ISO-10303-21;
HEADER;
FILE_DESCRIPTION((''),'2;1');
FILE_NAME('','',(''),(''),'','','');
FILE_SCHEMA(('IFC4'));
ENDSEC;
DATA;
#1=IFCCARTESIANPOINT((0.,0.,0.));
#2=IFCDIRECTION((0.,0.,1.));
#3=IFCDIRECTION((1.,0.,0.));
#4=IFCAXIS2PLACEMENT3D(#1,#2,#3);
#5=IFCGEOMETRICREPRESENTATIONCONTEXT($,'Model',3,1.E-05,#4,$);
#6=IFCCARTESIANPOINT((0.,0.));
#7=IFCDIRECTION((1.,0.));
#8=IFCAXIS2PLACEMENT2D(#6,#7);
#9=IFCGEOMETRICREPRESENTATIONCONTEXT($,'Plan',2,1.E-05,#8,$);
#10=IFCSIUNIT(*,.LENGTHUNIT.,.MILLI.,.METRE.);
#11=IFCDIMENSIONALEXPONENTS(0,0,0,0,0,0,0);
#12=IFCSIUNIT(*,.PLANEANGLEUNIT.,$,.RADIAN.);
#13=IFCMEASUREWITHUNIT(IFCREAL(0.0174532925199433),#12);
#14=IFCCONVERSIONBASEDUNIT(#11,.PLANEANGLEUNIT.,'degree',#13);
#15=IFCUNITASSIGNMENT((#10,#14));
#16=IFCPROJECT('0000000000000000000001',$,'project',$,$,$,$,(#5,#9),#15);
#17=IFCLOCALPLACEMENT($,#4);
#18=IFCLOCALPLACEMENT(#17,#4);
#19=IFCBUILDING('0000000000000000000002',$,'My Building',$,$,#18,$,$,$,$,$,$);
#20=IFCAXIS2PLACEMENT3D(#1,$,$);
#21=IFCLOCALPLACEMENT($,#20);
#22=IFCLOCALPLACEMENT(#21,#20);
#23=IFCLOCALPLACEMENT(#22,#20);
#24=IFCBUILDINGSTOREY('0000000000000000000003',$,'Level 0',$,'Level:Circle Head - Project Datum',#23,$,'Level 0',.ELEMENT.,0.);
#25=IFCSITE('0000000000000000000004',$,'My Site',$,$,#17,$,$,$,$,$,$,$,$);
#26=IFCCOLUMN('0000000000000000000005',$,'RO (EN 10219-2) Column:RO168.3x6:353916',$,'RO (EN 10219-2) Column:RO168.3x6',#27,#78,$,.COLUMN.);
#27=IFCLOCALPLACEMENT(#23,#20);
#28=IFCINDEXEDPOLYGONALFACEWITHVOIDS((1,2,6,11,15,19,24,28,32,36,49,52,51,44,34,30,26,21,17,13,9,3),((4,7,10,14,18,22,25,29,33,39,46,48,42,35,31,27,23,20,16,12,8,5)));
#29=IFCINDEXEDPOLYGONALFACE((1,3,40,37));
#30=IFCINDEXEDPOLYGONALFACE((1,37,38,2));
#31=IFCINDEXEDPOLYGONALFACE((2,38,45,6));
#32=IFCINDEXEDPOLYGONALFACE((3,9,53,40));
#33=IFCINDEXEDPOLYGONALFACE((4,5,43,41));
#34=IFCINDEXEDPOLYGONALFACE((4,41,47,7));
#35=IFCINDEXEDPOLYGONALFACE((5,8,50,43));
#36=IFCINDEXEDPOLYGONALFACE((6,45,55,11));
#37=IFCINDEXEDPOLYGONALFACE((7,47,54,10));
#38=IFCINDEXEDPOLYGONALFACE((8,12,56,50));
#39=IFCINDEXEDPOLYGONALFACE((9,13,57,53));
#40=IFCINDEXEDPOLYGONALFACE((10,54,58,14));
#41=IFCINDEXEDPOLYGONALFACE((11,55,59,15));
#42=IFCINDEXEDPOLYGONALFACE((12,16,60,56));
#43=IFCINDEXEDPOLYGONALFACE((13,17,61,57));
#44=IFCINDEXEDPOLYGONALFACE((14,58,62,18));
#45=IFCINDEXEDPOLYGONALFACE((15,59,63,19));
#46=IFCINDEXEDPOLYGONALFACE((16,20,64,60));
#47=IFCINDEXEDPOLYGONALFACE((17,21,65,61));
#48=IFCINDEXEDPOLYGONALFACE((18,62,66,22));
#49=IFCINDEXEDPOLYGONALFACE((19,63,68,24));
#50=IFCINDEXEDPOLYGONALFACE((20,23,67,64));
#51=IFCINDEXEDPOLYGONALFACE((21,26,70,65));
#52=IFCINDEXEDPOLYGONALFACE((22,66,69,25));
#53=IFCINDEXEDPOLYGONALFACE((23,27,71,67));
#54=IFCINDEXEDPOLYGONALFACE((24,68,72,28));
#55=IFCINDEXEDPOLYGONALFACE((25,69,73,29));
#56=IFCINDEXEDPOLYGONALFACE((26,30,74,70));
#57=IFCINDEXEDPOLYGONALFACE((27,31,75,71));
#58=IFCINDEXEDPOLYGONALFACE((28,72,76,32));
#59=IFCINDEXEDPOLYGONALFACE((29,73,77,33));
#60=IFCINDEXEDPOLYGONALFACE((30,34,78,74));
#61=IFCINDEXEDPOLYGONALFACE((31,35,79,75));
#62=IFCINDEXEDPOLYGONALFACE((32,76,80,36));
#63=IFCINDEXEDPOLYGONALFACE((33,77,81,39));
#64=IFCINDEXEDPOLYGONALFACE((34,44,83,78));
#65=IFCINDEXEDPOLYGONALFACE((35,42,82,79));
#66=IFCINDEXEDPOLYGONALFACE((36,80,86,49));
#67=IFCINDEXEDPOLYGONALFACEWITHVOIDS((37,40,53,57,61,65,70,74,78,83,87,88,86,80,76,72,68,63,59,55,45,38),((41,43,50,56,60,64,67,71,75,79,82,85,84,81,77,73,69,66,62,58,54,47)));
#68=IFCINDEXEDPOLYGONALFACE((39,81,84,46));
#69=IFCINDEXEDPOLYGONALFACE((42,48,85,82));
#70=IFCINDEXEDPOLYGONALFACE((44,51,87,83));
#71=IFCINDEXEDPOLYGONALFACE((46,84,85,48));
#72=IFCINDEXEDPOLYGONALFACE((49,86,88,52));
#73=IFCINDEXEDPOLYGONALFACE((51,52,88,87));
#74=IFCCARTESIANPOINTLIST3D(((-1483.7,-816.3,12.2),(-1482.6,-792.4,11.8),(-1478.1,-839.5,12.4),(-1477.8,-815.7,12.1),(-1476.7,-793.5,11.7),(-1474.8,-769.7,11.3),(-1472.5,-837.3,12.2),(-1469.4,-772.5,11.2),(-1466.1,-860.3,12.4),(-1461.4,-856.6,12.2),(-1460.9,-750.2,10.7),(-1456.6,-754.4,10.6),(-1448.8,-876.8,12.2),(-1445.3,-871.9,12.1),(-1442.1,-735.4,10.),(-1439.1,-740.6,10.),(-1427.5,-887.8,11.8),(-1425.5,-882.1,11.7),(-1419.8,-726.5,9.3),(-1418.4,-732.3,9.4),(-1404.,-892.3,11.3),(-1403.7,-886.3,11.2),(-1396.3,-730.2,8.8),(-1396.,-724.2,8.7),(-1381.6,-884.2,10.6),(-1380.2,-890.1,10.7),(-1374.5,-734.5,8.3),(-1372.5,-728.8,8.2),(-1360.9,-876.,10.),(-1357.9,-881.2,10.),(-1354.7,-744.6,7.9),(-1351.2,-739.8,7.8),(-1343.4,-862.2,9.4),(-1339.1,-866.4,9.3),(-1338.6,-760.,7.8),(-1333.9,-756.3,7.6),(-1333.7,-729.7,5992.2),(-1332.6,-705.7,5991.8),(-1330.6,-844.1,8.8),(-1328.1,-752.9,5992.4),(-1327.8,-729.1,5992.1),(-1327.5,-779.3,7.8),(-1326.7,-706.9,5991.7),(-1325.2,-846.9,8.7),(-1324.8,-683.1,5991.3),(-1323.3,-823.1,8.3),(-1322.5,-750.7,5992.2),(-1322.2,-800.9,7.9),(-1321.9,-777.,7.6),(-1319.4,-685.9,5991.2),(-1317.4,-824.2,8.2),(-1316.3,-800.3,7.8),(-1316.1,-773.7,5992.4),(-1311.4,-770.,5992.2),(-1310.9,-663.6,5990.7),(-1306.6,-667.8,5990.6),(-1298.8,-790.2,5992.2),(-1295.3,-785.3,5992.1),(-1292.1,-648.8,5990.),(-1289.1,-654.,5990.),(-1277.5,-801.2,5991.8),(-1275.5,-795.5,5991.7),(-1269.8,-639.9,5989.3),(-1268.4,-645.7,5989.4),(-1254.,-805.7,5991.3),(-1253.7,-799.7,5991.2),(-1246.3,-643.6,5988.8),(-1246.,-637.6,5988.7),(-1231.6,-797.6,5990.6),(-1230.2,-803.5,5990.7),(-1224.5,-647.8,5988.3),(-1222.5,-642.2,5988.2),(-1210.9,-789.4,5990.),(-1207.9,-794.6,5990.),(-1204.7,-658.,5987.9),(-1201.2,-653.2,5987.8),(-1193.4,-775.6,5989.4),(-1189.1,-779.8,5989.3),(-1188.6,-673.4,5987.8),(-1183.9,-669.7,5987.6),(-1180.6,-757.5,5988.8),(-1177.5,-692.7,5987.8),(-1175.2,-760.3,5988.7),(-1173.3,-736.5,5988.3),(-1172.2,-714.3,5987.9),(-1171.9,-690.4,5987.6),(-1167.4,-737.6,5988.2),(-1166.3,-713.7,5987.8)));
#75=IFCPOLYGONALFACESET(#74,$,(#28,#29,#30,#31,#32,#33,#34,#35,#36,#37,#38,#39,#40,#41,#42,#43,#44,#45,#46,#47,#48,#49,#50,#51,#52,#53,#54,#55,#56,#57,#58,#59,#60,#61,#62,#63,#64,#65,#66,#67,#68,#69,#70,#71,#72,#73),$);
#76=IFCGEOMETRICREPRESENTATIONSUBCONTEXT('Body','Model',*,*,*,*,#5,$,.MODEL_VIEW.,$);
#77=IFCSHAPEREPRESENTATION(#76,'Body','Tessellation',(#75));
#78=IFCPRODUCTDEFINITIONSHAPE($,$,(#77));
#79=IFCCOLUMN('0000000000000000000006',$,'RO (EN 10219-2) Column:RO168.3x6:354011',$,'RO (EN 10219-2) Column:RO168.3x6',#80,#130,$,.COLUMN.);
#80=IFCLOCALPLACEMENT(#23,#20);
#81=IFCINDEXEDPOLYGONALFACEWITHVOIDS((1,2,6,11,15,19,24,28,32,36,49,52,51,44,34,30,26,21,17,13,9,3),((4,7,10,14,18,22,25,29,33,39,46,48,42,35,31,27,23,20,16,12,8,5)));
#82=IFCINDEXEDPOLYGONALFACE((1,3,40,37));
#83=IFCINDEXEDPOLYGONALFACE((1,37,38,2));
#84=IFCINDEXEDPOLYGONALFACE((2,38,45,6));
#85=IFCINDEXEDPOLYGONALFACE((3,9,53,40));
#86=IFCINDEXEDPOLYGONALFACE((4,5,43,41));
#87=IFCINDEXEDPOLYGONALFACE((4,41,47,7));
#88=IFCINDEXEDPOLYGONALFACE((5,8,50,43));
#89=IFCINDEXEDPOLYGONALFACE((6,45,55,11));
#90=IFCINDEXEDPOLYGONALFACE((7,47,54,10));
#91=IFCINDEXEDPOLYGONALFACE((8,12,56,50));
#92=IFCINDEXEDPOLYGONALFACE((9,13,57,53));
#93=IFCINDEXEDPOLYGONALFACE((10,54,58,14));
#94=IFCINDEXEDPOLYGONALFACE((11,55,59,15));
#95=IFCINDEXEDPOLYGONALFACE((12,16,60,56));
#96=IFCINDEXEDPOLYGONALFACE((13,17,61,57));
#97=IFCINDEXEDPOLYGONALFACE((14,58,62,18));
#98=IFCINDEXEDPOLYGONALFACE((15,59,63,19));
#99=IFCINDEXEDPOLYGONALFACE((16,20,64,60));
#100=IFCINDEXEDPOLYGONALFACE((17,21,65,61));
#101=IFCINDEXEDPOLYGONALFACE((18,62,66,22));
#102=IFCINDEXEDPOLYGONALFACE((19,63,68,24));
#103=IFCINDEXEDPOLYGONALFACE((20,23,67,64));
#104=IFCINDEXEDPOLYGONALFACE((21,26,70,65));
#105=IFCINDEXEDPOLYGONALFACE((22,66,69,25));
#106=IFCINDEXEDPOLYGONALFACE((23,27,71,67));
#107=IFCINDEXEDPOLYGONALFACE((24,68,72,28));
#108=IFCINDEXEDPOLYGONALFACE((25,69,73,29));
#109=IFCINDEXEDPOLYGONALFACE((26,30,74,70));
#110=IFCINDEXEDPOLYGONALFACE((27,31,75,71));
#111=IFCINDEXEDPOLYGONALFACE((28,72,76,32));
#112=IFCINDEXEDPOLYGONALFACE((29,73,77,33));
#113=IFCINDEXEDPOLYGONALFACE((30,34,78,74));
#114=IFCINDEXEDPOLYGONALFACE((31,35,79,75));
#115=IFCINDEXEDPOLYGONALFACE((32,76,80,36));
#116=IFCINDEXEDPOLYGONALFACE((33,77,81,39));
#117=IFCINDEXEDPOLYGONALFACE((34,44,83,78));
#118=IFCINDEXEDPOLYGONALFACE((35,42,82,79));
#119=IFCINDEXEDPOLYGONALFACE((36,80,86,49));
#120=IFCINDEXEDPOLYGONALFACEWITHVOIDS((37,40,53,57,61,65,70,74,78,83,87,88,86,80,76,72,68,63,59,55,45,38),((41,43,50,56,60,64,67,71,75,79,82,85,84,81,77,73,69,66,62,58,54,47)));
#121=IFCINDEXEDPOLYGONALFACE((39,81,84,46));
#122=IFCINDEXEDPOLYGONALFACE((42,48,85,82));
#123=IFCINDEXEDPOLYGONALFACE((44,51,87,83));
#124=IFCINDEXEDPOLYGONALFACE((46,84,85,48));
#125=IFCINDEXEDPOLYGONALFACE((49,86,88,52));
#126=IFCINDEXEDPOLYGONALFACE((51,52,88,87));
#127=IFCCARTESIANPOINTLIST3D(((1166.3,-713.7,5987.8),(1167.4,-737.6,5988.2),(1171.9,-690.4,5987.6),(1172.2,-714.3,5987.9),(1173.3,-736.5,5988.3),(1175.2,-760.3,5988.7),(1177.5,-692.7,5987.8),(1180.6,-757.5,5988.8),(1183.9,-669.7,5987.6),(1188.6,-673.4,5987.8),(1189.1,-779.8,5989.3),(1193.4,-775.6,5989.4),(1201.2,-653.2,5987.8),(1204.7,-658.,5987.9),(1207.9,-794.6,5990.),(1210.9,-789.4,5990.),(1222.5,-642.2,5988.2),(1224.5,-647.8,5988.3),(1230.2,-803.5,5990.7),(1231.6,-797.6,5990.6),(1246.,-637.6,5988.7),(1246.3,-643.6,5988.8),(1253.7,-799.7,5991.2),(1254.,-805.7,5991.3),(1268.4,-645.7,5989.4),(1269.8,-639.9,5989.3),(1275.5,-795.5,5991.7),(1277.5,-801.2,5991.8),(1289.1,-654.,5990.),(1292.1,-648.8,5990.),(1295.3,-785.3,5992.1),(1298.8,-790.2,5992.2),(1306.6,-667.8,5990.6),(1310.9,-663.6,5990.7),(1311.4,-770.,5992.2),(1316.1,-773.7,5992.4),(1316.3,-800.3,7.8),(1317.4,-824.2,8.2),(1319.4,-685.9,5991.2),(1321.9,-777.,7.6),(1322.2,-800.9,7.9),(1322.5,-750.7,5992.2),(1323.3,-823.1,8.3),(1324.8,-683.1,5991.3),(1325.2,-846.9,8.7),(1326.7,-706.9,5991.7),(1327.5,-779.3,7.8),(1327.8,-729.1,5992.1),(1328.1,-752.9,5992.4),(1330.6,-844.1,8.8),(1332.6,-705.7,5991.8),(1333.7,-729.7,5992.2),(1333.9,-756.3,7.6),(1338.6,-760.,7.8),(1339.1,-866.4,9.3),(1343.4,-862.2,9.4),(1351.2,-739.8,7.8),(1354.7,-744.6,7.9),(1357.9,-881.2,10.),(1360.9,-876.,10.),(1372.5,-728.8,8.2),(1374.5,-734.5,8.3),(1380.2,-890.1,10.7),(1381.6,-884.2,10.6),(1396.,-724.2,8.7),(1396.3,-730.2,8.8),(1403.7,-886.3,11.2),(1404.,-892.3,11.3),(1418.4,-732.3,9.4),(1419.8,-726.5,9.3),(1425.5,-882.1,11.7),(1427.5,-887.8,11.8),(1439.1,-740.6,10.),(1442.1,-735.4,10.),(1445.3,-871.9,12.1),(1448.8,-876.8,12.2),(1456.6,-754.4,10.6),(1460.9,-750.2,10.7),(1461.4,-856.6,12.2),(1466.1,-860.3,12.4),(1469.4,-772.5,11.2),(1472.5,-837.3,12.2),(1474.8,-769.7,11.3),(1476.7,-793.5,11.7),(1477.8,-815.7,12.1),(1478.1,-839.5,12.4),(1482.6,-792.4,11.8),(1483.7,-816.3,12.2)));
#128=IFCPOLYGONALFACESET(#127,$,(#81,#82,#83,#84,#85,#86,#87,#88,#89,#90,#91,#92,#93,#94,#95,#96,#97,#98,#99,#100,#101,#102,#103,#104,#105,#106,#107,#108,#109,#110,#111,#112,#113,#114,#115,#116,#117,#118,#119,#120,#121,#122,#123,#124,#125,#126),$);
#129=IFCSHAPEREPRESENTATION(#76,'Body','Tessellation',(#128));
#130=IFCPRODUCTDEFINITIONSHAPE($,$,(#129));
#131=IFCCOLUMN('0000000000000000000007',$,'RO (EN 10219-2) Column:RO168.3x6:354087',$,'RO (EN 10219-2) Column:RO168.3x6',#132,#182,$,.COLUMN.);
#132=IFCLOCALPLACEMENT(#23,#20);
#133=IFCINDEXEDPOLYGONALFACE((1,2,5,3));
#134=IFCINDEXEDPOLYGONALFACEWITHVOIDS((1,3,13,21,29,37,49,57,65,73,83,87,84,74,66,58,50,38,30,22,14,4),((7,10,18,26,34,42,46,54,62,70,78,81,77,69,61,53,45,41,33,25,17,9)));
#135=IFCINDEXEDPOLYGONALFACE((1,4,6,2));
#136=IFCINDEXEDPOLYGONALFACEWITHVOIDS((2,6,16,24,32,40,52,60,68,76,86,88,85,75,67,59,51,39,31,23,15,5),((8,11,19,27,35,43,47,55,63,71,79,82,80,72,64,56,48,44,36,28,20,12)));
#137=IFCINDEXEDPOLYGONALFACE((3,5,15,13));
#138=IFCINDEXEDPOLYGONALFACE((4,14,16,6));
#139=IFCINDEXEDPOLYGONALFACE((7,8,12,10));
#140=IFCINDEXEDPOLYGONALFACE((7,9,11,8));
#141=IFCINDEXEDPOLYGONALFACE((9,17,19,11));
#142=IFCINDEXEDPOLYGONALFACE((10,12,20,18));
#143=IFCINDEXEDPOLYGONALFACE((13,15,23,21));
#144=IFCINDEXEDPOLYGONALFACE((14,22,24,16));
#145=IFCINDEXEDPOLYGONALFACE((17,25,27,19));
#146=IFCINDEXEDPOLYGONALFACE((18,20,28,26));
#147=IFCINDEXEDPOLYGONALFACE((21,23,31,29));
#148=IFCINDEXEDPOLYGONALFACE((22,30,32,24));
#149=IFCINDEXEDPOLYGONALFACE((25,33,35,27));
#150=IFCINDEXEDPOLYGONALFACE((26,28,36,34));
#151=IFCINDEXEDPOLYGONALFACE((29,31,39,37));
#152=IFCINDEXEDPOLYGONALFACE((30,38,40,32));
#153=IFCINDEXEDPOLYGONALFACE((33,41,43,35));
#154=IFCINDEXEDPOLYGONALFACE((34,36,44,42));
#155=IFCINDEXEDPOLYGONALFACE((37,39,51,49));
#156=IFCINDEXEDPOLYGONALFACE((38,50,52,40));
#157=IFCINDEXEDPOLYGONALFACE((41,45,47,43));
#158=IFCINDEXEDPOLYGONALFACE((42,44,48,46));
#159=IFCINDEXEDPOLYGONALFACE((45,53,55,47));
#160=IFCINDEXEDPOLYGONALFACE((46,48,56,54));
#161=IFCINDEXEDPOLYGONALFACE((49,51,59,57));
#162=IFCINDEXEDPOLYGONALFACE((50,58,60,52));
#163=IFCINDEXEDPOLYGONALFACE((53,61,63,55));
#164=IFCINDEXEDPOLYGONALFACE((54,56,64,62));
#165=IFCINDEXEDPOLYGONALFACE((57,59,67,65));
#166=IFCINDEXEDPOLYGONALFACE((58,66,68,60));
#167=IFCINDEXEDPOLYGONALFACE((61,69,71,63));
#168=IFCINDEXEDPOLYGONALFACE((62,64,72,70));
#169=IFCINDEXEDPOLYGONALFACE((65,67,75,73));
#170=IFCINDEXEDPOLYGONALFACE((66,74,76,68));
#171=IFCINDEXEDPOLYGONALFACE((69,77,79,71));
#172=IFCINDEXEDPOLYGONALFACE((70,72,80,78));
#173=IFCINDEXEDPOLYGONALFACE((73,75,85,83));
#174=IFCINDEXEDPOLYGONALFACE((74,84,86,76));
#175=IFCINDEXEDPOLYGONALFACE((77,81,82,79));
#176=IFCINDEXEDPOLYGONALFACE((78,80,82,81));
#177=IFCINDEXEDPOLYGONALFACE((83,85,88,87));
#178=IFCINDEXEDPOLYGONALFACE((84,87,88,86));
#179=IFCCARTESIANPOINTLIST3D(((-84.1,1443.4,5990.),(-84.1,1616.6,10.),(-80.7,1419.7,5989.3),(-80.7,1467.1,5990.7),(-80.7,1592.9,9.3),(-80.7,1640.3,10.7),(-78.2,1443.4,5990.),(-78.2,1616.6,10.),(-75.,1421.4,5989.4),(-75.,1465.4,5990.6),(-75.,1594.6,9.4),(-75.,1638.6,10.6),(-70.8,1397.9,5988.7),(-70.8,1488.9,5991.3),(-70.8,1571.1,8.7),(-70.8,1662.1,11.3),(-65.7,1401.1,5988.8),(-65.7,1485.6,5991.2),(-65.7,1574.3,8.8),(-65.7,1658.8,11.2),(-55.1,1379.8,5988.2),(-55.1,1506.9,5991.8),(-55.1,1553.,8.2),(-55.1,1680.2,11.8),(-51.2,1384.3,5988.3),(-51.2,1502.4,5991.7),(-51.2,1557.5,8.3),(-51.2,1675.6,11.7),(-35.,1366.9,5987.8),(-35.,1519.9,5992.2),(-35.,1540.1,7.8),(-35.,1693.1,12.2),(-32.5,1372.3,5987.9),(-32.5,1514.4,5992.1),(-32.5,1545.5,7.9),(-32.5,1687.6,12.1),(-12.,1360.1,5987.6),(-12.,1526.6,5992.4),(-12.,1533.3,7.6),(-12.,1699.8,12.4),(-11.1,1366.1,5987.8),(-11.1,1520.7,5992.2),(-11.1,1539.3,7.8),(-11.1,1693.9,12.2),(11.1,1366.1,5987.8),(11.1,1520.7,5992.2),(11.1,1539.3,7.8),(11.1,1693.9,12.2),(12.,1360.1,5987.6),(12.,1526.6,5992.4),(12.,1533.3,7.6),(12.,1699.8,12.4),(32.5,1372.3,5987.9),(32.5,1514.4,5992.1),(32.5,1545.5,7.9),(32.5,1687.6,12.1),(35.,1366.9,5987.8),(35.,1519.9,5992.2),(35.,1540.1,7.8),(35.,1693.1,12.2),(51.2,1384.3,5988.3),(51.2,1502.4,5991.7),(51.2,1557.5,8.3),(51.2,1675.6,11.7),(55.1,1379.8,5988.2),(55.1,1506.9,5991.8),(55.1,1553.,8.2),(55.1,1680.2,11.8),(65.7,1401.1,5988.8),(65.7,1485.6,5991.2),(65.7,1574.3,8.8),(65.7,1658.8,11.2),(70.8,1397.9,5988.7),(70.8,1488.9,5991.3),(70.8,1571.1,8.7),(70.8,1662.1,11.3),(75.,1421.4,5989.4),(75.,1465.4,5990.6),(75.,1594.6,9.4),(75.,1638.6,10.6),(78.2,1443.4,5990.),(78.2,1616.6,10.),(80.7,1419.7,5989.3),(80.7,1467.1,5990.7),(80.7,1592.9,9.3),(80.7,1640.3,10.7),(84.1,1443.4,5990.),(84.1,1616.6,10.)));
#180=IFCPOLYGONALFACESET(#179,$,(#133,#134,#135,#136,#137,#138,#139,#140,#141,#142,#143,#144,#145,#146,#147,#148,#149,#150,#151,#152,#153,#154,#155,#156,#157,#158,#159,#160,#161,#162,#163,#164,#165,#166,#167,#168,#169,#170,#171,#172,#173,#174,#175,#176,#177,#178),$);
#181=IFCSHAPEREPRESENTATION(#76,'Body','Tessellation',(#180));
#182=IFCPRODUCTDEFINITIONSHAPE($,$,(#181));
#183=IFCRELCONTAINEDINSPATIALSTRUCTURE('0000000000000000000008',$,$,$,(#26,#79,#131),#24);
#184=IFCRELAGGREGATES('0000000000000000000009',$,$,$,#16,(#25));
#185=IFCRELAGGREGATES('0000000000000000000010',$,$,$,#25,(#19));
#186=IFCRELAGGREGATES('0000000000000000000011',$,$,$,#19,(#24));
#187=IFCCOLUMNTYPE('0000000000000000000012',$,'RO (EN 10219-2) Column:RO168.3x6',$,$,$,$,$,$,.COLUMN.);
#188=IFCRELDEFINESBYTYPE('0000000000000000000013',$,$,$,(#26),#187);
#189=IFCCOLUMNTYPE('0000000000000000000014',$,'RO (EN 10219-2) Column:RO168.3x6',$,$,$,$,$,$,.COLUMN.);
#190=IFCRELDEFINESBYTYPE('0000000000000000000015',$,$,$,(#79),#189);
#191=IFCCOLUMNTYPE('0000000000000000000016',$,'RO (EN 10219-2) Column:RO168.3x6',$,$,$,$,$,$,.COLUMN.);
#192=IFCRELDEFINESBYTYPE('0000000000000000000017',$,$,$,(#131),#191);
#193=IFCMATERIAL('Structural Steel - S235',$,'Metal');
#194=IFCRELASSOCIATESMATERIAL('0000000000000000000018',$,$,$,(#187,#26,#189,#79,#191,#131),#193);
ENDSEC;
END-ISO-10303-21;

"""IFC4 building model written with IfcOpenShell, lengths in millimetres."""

from ifc_helpers import new_model, entity, si_unit, converted_unit, frame, origin, origin_with_axes, origin_2d_with_axis, place, context, subcontext, project, spatial, arc, indexed_curve, outline, extrude, source, transform, mapped, material, type_object, type_shapes, element, save


model = new_model("IFC4")

# Units and contexts
model_context = context("Model", 3, precision=1e-05, world=origin_with_axes())
plan_context = context("Plan", 2, precision=1e-05, world=origin_2d_with_axis())
body_context = subcontext(model_context, "Body", "Model", "MODEL_VIEW")
ifc_project = project(units=[si_unit("LENGTHUNIT", "METRE", prefix="MILLI"), converted_unit("PLANEANGLEUNIT", "degree", entity("IfcReal", 0.0174532925199433), si_unit("PLANEANGLEUNIT", "RADIAN"), dimensions=[0, 0, 0, 0, 0, 0, 0])], contexts=[model_context, plan_context])

# Site, building, storey
site_placement = place(None, origin_with_axes())
site = spatial("IfcSite", under=ifc_project, at=site_placement, Name="My Site")
building_placement = place(site_placement, origin_with_axes())
building = spatial("IfcBuilding", under=site, at=building_placement, Name="My Building")
placement_1 = place(None, origin())
placement_2 = place(placement_1, origin())
storey_placement = place(placement_2, origin())
storey = spatial("IfcBuildingStorey", under=building, at=storey_placement, Name="Level 0", ObjectType="Level:Circle Head - Project Datum", LongName="Level 0", CompositionType="ELEMENT", Elevation=0.0)

# Columns
ifc_material_1 = material(Name="Structural Steel - S235", Category="Metal")
column_type_1 = type_object("IfcColumnType", Name="RO (EN 10219-2) Column:RO168.3x6", PredefinedType="COLUMN", material=ifc_material_1)
shared_shape_1 = source(origin(), body_context, "Body", "SweptSolid", [
    extrude(outline(indexed_curve([(-84.2, 0.0), (0.0, -84.1), (84.1, 0.0), (0.0, 84.1)], segments=[arc(1, 2, 3), arc(3, 4, 1)], self_intersect=False), holes=[indexed_curve([(-78.2, 0.0), (0.0, 78.2), (78.2, 0.0), (0.0, -78.2)], segments=[arc(1, 2, 3), arc(3, 4, 1)], self_intersect=False)]), frame((-1400.0, -808.3, 10.0), z_axis=(0.025073, 0.014476, 0.999581), x_axis=(-0.5, 0.866025, 0.0)), (0.0, 0.0, 1.0), 5982.5),
])
type_shapes(column_type_1, [shared_shape_1])
column_1_placement = place(storey_placement, origin())
element("IfcColumn", 1, at=column_1_placement, inside=storey, type_object=column_type_1, material=ifc_material_1, Name="RO (EN 10219-2) Column:RO168.3x6:353916", ObjectType="RO (EN 10219-2) Column:RO168.3x6", PredefinedType="COLUMN", context=body_context, shape_type="MappedRepresentation", body=[
    mapped(shared_shape_1, transform((0.0, 0.0, 0.0), scale=1.0)),
])
column_type_2 = type_object("IfcColumnType", Name="RO (EN 10219-2) Column:RO168.3x6", PredefinedType="COLUMN", material=ifc_material_1)
shared_shape_2 = source(origin(), body_context, "Body", "SweptSolid", [
    extrude(outline(indexed_curve([(-84.2, 0.0), (0.0, -84.1), (84.2, 0.0), (0.0, 84.1)], segments=[arc(1, 2, 3), arc(3, 4, 1)], self_intersect=False), holes=[indexed_curve([(-78.2, 0.0), (0.0, 78.2), (78.2, 0.0), (0.0, -78.2)], segments=[arc(1, 2, 3), arc(3, 4, 1)], self_intersect=False)]), frame((1250.0, -721.7, 5990.0), z_axis=(0.025073, -0.014476, -0.999581), x_axis=(-0.5, -0.866025, 0.0)), (0.0, 0.0, 1.0), 5982.5),
])
type_shapes(column_type_2, [shared_shape_2])
column_2_placement = place(storey_placement, origin())
element("IfcColumn", 2, at=column_2_placement, inside=storey, type_object=column_type_2, material=ifc_material_1, Name="RO (EN 10219-2) Column:RO168.3x6:354011", ObjectType="RO (EN 10219-2) Column:RO168.3x6", PredefinedType="COLUMN", context=body_context, shape_type="MappedRepresentation", body=[
    mapped(shared_shape_2, transform((0.0, 0.0, 0.0), scale=1.0)),
])
column_type_3 = type_object("IfcColumnType", Name="RO (EN 10219-2) Column:RO168.3x6", PredefinedType="COLUMN", material=ifc_material_1)
shared_shape_3 = source(origin(), body_context, "Body", "SweptSolid", [
    extrude(outline(indexed_curve([(-84.1, 0.0), (0.0, -84.1), (84.1, 0.0), (0.0, 84.1)], segments=[arc(1, 2, 3), arc(3, 4, 1)], self_intersect=False), holes=[indexed_curve([(-78.2, 0.0), (0.0, 78.2), (78.2, 0.0), (0.0, -78.2)], segments=[arc(1, 2, 3), arc(3, 4, 1)], self_intersect=False)]), frame((0.0, 1443.4, 5990.0), z_axis=(0.0, 0.028952, -0.999581), x_axis=(1.0, 0.0, 0.0)), (0.0, 0.0, 1.0), 5982.5),
])
type_shapes(column_type_3, [shared_shape_3])
column_3_placement = place(storey_placement, origin())
element("IfcColumn", 3, at=column_3_placement, inside=storey, type_object=column_type_3, material=ifc_material_1, Name="RO (EN 10219-2) Column:RO168.3x6:354087", ObjectType="RO (EN 10219-2) Column:RO168.3x6", PredefinedType="COLUMN", context=body_context, shape_type="MappedRepresentation", body=[
    mapped(shared_shape_3, transform((0.0, 0.0, 0.0), scale=1.0)),
])

save(model, "model.ifc")
